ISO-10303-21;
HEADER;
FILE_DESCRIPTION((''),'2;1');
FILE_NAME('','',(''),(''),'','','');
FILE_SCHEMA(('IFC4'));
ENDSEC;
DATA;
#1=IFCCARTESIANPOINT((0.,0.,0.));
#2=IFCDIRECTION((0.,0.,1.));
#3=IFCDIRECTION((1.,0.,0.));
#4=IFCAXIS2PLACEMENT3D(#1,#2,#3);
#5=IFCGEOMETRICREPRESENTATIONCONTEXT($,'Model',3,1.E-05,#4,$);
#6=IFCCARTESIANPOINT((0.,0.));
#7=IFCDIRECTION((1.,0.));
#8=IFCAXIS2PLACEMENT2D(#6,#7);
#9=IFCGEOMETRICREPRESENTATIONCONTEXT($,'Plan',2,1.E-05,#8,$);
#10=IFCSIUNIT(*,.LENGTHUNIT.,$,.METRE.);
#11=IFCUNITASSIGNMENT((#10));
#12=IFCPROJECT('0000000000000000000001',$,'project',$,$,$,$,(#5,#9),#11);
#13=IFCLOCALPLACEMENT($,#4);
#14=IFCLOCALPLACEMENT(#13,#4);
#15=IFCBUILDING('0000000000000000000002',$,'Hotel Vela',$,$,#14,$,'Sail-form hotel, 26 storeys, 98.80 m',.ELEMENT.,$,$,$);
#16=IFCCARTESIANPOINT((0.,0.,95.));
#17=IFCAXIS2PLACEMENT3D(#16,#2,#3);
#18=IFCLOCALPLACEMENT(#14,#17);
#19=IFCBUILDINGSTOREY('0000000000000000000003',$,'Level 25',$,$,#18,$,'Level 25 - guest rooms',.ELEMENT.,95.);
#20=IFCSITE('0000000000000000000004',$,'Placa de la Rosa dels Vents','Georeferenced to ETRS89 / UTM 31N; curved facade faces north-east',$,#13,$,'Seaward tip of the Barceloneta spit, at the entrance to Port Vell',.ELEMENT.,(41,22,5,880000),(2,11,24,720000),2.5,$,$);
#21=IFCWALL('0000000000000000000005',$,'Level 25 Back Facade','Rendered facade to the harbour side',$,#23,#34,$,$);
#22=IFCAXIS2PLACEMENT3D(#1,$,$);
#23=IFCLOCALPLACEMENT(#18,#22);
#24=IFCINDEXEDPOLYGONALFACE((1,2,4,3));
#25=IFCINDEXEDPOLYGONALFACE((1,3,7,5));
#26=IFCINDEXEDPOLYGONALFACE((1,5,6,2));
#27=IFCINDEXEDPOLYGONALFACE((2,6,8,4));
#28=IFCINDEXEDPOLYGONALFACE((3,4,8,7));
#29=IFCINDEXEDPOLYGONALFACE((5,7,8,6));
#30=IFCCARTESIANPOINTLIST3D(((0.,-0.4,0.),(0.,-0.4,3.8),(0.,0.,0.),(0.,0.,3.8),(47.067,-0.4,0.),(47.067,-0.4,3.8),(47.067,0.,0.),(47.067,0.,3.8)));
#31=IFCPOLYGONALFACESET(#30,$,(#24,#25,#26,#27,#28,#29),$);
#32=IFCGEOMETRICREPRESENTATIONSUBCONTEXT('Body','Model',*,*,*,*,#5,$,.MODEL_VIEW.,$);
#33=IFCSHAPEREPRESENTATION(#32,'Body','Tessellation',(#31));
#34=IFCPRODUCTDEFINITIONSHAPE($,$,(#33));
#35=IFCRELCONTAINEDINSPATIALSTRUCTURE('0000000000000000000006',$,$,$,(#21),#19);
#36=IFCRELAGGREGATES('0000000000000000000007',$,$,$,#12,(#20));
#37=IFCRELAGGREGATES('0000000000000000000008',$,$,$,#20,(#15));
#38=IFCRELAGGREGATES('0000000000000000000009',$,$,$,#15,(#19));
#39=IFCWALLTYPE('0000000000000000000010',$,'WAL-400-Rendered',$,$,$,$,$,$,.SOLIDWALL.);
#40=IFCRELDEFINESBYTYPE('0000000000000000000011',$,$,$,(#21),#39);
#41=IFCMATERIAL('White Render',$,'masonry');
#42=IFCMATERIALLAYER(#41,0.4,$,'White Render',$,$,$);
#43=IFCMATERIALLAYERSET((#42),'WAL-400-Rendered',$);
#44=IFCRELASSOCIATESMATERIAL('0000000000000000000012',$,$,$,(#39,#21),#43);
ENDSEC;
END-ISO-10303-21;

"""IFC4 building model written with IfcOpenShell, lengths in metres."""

from ifc_helpers import new_model, si_unit, frame, origin_with_axes, origin_2d_with_axis, place, context, subcontext, project, spatial, line, indexed_curve, outline, extrude, material, layer, layer_set, layer_usage, type_object, element, save


model = new_model("IFC4")

# Units and contexts
model_context = context("Model", 3, precision=1e-05, world=origin_with_axes())
plan_context = context("Plan", 2, precision=1e-05, world=origin_2d_with_axis())
body_context = subcontext(model_context, "Body", "Model", "MODEL_VIEW")
ifc_project = project(units=[si_unit("LENGTHUNIT", "METRE")], contexts=[model_context, plan_context])

# Site, building, storey
site_placement = place(None, origin_with_axes())
site = spatial("IfcSite", under=ifc_project, at=site_placement, Name="Placa de la Rosa dels Vents", Description="Georeferenced to ETRS89 / UTM 31N; curved facade faces north-east", LongName="Seaward tip of the Barceloneta spit, at the entrance to Port Vell", CompositionType="ELEMENT", RefLatitude=(41, 22, 5, 880000), RefLongitude=(2, 11, 24, 720000), RefElevation=2.5)
building_placement = place(site_placement, origin_with_axes())
building = spatial("IfcBuilding", under=site, at=building_placement, Name="Hotel Vela", LongName="Sail-form hotel, 26 storeys, 98.80 m", CompositionType="ELEMENT")
storey_placement = place(building_placement, frame((0.0, 0.0, 95.0), z_axis=(0.0, 0.0, 1.0), x_axis=(1.0, 0.0, 0.0)))
storey = spatial("IfcBuildingStorey", under=building, at=storey_placement, Name="Level 25", LongName="Level 25 - guest rooms", CompositionType="ELEMENT", Elevation=95.0)

# Wall
ifc_material_1 = material(Name="White Render", Category="masonry")
ifc_layer_1 = layer(ifc_material_1, 0.4, Name="White Render")
ifc_layer_set_1 = layer_set([ifc_layer_1], Name="WAL-400-Rendered")
ifc_layer_usage_1 = layer_usage(ifc_layer_set_1, "AXIS2", "POSITIVE", 0.0)
wall_type = type_object("IfcWallType", Name="WAL-400-Rendered", PredefinedType="SOLIDWALL", material=ifc_layer_set_1)
wall_placement = place(storey_placement, frame((0.0, -0.4, 0.0), z_axis=(0.0, 0.0, 1.0), x_axis=(1.0, 0.0, 0.0)))
element("IfcWall", 1, at=wall_placement, inside=storey, type_object=wall_type, material=ifc_layer_usage_1, Name="Level 25 Back Facade", Description="Rendered facade to the harbour side", context=body_context, shape_type="SweptSolid", body=[
    extrude(outline(indexed_curve([(0.0, 0.0), (47.067, 0.0), (47.067, 0.4), (0.0, 0.4)], segments=[line(1, 2, 3, 4, 1)])), origin_with_axes(), (0.0, 0.0, 1.0), 3.8),
])

save(model, "model.ifc")
